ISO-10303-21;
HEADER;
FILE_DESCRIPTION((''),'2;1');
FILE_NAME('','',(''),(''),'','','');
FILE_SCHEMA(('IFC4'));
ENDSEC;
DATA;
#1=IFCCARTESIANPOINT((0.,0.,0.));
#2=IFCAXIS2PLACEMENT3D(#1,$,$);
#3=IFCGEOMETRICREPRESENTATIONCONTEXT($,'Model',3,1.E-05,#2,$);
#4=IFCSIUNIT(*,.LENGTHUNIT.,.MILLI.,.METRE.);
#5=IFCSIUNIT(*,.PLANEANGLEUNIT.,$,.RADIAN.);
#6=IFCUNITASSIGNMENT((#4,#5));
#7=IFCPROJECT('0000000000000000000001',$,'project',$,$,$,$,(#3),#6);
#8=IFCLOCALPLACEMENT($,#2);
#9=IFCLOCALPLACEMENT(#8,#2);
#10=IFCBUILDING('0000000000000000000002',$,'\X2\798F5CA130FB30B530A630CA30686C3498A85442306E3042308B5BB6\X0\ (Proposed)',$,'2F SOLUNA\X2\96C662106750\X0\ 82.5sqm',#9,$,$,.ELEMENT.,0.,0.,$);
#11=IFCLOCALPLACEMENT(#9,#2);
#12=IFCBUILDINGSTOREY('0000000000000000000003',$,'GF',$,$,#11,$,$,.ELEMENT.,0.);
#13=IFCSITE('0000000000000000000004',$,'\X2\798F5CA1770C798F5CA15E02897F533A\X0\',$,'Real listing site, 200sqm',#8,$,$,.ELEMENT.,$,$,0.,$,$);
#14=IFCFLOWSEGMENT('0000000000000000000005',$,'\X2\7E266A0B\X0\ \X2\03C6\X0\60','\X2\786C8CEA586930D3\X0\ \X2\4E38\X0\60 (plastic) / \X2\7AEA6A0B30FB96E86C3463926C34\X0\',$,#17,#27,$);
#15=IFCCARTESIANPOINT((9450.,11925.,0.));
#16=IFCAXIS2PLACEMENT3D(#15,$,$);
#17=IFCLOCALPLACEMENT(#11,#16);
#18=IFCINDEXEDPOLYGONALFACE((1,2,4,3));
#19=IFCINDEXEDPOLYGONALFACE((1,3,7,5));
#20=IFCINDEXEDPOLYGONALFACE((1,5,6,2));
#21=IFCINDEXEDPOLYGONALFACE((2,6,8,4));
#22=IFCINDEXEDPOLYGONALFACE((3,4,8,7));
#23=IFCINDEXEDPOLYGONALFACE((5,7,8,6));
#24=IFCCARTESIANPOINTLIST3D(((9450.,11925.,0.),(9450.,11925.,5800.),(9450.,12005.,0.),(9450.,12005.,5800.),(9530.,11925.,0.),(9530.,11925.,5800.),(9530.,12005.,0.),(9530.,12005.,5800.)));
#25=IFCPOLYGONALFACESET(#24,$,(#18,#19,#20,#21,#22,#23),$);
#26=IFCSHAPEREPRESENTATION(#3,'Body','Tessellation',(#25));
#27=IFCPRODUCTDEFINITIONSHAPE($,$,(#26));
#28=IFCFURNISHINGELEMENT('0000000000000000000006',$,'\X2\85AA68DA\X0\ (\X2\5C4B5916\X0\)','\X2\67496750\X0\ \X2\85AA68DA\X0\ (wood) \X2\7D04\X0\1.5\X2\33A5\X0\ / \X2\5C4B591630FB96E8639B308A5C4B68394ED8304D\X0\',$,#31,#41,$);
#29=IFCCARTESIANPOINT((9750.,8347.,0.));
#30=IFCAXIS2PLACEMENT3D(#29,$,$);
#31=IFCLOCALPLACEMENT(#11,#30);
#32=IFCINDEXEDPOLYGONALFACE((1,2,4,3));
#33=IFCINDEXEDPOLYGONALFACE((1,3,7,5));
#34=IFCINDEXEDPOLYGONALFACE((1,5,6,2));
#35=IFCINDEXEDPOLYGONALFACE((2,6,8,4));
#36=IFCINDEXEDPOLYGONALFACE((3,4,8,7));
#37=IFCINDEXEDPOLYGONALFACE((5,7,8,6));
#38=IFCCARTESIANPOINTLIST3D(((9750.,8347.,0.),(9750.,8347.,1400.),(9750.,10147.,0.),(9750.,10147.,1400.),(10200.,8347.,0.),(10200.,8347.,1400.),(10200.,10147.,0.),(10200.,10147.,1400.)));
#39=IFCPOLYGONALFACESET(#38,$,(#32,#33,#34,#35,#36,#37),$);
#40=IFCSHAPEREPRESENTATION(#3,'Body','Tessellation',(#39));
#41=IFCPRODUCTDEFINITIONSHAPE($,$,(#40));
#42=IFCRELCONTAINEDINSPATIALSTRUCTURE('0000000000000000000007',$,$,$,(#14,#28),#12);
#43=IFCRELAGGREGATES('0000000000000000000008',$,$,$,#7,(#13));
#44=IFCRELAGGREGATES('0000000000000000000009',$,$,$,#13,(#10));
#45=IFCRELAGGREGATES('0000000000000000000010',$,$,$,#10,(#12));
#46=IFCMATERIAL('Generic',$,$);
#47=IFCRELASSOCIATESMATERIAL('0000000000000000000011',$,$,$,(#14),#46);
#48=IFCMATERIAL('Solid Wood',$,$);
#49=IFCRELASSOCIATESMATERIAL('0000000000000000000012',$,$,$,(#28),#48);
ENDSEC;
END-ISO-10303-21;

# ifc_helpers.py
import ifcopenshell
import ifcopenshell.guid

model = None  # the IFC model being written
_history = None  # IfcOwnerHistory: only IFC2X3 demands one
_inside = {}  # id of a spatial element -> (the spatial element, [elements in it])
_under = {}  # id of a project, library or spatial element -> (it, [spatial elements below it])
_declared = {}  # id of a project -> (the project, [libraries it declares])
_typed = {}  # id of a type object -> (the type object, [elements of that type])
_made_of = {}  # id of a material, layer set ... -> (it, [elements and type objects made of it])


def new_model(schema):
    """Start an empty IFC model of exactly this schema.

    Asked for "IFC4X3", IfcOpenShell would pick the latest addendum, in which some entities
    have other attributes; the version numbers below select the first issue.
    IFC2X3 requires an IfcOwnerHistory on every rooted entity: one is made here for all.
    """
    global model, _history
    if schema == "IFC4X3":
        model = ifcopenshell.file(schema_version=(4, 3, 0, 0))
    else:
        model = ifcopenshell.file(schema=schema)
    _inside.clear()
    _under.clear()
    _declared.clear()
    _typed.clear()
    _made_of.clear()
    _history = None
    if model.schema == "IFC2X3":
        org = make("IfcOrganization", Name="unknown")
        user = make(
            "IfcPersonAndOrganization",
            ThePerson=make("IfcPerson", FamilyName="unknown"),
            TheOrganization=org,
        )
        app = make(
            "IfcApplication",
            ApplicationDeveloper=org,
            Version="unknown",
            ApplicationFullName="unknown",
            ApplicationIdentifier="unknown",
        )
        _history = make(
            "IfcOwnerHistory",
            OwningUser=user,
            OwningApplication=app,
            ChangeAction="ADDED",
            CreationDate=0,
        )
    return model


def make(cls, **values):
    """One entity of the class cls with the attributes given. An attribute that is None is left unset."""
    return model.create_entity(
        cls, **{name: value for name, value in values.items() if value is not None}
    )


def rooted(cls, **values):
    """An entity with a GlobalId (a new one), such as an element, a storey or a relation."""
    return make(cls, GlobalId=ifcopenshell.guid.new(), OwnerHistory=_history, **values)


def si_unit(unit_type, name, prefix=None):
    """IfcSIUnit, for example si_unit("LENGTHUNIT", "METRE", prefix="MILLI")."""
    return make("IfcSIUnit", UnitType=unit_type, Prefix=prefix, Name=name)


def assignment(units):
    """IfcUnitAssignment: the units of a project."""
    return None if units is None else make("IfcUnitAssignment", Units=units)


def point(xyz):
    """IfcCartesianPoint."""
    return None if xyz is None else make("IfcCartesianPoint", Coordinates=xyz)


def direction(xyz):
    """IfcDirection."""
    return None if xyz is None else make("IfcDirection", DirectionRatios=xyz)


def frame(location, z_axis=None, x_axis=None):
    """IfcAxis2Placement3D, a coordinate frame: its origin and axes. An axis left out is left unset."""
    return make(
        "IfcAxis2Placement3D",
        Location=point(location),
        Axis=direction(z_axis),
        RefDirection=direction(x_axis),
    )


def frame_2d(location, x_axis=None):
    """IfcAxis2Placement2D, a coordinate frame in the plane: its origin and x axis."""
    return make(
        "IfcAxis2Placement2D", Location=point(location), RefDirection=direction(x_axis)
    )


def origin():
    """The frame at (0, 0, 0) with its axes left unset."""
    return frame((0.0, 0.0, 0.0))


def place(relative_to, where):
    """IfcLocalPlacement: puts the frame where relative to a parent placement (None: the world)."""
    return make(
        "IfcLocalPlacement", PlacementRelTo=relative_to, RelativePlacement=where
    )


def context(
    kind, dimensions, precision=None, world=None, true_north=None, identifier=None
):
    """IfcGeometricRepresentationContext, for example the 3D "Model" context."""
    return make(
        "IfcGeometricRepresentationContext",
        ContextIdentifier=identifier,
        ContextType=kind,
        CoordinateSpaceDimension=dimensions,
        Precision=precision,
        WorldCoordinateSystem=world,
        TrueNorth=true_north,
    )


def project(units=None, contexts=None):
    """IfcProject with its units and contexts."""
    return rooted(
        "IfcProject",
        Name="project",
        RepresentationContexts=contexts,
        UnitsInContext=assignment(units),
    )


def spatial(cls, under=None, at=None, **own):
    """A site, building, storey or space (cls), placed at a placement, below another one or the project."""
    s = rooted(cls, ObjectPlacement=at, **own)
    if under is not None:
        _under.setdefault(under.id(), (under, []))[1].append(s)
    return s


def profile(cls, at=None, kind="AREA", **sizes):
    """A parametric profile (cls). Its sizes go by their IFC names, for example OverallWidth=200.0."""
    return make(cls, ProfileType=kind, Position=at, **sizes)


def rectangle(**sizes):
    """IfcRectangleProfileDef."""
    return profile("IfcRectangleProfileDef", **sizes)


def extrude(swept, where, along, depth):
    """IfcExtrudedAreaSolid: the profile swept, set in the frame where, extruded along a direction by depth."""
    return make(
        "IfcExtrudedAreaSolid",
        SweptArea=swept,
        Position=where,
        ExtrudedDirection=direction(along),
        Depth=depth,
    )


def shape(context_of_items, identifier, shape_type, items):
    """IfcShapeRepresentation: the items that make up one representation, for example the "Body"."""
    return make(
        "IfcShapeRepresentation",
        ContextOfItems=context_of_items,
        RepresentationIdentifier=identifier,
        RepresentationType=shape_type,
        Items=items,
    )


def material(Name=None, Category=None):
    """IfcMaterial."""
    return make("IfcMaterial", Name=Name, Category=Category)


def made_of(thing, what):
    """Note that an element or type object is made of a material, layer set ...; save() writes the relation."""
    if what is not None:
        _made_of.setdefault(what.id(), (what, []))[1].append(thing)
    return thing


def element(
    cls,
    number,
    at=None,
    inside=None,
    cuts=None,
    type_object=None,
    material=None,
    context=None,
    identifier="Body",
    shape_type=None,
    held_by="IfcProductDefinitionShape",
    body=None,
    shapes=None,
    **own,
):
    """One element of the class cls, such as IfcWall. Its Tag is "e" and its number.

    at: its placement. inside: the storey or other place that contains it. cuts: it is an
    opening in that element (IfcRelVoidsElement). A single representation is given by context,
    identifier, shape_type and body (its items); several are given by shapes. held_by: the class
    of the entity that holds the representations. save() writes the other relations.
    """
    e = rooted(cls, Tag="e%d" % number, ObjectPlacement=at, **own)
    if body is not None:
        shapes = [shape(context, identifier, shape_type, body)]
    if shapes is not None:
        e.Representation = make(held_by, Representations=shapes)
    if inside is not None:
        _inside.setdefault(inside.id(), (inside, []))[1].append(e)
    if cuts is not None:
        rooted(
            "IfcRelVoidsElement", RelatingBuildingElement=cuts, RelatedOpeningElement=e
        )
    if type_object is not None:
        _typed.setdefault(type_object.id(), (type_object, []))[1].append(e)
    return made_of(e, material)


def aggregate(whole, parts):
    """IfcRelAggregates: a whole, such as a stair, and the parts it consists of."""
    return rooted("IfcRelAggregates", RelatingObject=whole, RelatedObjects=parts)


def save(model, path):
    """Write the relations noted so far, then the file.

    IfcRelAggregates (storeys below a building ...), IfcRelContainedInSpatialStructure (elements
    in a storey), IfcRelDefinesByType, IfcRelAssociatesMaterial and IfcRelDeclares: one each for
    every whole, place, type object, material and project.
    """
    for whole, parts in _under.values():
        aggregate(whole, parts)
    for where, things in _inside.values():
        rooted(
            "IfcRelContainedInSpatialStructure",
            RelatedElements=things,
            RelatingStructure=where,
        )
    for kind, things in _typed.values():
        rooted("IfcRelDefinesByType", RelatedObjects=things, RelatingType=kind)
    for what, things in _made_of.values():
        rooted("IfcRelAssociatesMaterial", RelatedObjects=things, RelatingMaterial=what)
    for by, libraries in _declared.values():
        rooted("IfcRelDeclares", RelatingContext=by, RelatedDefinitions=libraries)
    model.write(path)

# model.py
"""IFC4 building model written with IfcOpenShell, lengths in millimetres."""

from ifc_helpers import new_model, si_unit, frame, frame_2d, origin, place, context, project, spatial, rectangle, extrude, material, element, save


model = new_model("IFC4")

# Units and contexts
model_context = context("Model", 3, precision=1e-05, world=origin())
ifc_project = project(units=[si_unit("LENGTHUNIT", "METRE", prefix="MILLI"), si_unit("PLANEANGLEUNIT", "RADIAN")], contexts=[model_context])

# Site, building, storey
site_placement = place(None, origin())
site = spatial("IfcSite", under=ifc_project, at=site_placement, Name="福岡県福岡市西区", ObjectType="Real listing site, 200sqm", CompositionType="ELEMENT", RefElevation=0.0)
building_placement = place(site_placement, origin())
building = spatial("IfcBuilding", under=site, at=building_placement, Name="福岡・サウナと水風呂のある家 (Proposed)", ObjectType="2F SOLUNA集成材 82.5sqm", CompositionType="ELEMENT", ElevationOfRefHeight=0.0, ElevationOfTerrain=0.0)
storey_placement = place(building_placement, origin())
storey = spatial("IfcBuildingStorey", under=building, at=storey_placement, Name="GF", CompositionType="ELEMENT", Elevation=0.0)

# Shared definitions
ifc_material_1 = material(Name="Solid Wood")

# Flow segment
ifc_material_2 = material(Name="Generic")
flow_segment_placement = place(storey_placement, frame((9450.0, 11925.0, 0.0)))
element("IfcFlowSegment", 1, at=flow_segment_placement, inside=storey, material=ifc_material_2, Name="縦樋 φ60", Description="硬質塩ビ 丸60 (plastic) / 竪樋・雨水排水", context=model_context, shape_type="SweptSolid", body=[
    extrude(rectangle(XDim=80.0, YDim=80.0, at=frame_2d((40.0, 40.0))), frame((9450.0, 11925.0, 0.0)), (0.0, 0.0, 1.0), 5800.0),
])

# Furnishing element
furnishing_placement = place(storey_placement, frame((9750.0, 8347.0, 0.0)))
element("IfcFurnishingElement", 2, at=furnishing_placement, inside=storey, material=ifc_material_1, Name="薪棚 (屋外)", Description="杉材 薪棚 (wood) 約1.5㎥ / 屋外・雨掛り屋根付き", context=model_context, shape_type="SweptSolid", body=[
    extrude(rectangle(XDim=450.0, YDim=1800.0, at=frame_2d((225.0, 900.0))), frame((9750.0, 8347.0, 0.0)), (0.0, 0.0, 1.0), 1400.0),
])

save(model, "model.ifc")
